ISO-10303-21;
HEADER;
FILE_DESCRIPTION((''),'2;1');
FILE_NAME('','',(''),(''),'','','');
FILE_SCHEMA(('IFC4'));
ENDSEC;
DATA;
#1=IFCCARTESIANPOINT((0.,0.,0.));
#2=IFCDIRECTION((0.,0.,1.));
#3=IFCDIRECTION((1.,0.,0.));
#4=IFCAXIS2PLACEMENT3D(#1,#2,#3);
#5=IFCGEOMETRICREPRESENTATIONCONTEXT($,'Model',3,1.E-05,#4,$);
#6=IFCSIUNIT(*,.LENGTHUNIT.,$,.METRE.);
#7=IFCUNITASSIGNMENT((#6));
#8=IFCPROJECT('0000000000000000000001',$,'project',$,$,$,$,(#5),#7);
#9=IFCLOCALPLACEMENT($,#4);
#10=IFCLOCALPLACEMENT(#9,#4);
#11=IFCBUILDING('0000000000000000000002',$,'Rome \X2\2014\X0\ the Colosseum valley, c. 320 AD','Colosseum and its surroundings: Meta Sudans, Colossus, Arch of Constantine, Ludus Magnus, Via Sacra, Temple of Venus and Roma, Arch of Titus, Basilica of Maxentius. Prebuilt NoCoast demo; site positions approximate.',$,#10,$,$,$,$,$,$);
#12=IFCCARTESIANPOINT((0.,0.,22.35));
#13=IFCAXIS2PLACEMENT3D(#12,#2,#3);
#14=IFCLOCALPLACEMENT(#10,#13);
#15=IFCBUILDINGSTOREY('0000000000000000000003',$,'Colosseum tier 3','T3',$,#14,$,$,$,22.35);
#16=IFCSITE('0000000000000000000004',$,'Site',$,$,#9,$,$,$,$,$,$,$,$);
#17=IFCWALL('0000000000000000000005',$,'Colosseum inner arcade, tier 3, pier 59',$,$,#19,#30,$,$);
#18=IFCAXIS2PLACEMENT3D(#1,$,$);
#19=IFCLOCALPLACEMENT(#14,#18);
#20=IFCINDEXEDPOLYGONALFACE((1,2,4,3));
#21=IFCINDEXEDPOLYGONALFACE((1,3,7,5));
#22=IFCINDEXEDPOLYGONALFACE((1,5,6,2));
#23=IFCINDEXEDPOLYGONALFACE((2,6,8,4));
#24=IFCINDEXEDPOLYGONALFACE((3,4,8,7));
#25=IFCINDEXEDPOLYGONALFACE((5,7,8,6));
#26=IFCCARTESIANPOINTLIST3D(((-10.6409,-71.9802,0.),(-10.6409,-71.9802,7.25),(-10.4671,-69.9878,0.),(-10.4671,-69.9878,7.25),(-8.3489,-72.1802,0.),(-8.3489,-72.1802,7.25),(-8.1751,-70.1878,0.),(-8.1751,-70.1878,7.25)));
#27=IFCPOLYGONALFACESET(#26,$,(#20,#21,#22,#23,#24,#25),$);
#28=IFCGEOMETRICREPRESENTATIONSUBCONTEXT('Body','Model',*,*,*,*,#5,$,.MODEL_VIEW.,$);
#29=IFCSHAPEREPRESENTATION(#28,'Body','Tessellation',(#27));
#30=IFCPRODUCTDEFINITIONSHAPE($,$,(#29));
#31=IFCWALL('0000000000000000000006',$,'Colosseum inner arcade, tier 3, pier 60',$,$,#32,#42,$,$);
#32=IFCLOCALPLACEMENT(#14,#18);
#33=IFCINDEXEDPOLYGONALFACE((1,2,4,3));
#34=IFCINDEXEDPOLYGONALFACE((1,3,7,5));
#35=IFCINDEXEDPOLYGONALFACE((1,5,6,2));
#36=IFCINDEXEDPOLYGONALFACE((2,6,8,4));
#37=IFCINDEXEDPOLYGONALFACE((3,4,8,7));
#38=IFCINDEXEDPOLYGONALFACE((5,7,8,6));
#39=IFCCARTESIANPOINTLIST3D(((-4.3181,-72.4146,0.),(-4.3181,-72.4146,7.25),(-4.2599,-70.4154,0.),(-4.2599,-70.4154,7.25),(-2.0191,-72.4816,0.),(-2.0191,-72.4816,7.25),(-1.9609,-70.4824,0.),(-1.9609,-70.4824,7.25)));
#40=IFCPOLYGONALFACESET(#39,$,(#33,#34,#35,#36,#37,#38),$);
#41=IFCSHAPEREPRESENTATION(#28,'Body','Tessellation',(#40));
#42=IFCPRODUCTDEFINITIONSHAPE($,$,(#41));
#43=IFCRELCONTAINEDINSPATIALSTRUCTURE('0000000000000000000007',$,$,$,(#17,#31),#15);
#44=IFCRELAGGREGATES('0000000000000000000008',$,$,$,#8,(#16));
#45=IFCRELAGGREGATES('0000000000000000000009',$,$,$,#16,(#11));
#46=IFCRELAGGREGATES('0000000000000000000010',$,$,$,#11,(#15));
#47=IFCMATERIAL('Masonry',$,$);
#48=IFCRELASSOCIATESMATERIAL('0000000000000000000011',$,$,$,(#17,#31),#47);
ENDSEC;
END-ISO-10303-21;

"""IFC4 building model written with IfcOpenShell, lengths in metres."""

from ifc_helpers import new_model, si_unit, frame, origin_with_axes, place, context, subcontext, project, spatial, indexed_curve, outline, extrude, material, element, save


model = new_model("IFC4")

# Units and contexts
model_context = context("Model", 3, precision=1e-05, world=origin_with_axes())
body_context = subcontext(model_context, "Body", "Model", "MODEL_VIEW")
ifc_project = project(units=[si_unit("LENGTHUNIT", "METRE")], contexts=[model_context])

# Site, building, storey
site_placement = place(None, origin_with_axes())
site = spatial("IfcSite", under=ifc_project, at=site_placement, Name="Site")
building_placement = place(site_placement, origin_with_axes())
building = spatial("IfcBuilding", under=site, at=building_placement, Name="Rome — the Colosseum valley, c. 320 AD", Description="Colosseum and its surroundings: Meta Sudans, Colossus, Arch of Constantine, Ludus Magnus, Via Sacra, Temple of Venus and Roma, Arch of Titus, Basilica of Maxentius. Prebuilt NoCoast demo; site positions approximate.")
storey_placement = place(building_placement, frame((0.0, 0.0, 22.35), z_axis=(0.0, 0.0, 1.0), x_axis=(1.0, 0.0, 0.0)))
storey = spatial("IfcBuildingStorey", under=building, at=storey_placement, Name="Colosseum tier 3", Description="T3", Elevation=22.35)

# Walls
ifc_material_1 = material(Name="Masonry")
wall_1_placement = place(storey_placement, frame((-10.554, -70.984, 0.0), z_axis=(0.0, 0.0, 1.0), x_axis=(0.996214, -0.08693, 0.0)))
element("IfcWall", 1, at=wall_1_placement, inside=storey, material=ifc_material_1, Name="Colosseum inner arcade, tier 3, pier 59", context=body_context, shape_type="SweptSolid", body=[
    extrude(outline(indexed_curve([(0.0, 0.0), (0.0, 2.0), (2.3007, 2.0), (2.3007, 0.0), (0.0, 0.0)], self_intersect=False)), frame((0.0, -1.0, 0.0), z_axis=(0.0, 0.0, 1.0), x_axis=(1.0, 0.0, 0.0)), (0.0, 0.0, 1.0), 7.25),
])
wall_2_placement = place(storey_placement, frame((-4.289, -71.415, 0.0), z_axis=(0.0, 0.0, 1.0), x_axis=(0.999576, -0.029131, 0.0)))
element("IfcWall", 2, at=wall_2_placement, inside=storey, material=ifc_material_1, Name="Colosseum inner arcade, tier 3, pier 60", context=body_context, shape_type="SweptSolid", body=[
    extrude(outline(indexed_curve([(0.0, 0.0), (0.0, 2.0), (2.3, 2.0), (2.3, 0.0), (0.0, 0.0)], self_intersect=False)), frame((0.0, -1.0, 0.0), z_axis=(0.0, 0.0, 1.0), x_axis=(1.0, 0.0, 0.0)), (0.0, 0.0, 1.0), 7.25),
])

save(model, "model.ifc")
